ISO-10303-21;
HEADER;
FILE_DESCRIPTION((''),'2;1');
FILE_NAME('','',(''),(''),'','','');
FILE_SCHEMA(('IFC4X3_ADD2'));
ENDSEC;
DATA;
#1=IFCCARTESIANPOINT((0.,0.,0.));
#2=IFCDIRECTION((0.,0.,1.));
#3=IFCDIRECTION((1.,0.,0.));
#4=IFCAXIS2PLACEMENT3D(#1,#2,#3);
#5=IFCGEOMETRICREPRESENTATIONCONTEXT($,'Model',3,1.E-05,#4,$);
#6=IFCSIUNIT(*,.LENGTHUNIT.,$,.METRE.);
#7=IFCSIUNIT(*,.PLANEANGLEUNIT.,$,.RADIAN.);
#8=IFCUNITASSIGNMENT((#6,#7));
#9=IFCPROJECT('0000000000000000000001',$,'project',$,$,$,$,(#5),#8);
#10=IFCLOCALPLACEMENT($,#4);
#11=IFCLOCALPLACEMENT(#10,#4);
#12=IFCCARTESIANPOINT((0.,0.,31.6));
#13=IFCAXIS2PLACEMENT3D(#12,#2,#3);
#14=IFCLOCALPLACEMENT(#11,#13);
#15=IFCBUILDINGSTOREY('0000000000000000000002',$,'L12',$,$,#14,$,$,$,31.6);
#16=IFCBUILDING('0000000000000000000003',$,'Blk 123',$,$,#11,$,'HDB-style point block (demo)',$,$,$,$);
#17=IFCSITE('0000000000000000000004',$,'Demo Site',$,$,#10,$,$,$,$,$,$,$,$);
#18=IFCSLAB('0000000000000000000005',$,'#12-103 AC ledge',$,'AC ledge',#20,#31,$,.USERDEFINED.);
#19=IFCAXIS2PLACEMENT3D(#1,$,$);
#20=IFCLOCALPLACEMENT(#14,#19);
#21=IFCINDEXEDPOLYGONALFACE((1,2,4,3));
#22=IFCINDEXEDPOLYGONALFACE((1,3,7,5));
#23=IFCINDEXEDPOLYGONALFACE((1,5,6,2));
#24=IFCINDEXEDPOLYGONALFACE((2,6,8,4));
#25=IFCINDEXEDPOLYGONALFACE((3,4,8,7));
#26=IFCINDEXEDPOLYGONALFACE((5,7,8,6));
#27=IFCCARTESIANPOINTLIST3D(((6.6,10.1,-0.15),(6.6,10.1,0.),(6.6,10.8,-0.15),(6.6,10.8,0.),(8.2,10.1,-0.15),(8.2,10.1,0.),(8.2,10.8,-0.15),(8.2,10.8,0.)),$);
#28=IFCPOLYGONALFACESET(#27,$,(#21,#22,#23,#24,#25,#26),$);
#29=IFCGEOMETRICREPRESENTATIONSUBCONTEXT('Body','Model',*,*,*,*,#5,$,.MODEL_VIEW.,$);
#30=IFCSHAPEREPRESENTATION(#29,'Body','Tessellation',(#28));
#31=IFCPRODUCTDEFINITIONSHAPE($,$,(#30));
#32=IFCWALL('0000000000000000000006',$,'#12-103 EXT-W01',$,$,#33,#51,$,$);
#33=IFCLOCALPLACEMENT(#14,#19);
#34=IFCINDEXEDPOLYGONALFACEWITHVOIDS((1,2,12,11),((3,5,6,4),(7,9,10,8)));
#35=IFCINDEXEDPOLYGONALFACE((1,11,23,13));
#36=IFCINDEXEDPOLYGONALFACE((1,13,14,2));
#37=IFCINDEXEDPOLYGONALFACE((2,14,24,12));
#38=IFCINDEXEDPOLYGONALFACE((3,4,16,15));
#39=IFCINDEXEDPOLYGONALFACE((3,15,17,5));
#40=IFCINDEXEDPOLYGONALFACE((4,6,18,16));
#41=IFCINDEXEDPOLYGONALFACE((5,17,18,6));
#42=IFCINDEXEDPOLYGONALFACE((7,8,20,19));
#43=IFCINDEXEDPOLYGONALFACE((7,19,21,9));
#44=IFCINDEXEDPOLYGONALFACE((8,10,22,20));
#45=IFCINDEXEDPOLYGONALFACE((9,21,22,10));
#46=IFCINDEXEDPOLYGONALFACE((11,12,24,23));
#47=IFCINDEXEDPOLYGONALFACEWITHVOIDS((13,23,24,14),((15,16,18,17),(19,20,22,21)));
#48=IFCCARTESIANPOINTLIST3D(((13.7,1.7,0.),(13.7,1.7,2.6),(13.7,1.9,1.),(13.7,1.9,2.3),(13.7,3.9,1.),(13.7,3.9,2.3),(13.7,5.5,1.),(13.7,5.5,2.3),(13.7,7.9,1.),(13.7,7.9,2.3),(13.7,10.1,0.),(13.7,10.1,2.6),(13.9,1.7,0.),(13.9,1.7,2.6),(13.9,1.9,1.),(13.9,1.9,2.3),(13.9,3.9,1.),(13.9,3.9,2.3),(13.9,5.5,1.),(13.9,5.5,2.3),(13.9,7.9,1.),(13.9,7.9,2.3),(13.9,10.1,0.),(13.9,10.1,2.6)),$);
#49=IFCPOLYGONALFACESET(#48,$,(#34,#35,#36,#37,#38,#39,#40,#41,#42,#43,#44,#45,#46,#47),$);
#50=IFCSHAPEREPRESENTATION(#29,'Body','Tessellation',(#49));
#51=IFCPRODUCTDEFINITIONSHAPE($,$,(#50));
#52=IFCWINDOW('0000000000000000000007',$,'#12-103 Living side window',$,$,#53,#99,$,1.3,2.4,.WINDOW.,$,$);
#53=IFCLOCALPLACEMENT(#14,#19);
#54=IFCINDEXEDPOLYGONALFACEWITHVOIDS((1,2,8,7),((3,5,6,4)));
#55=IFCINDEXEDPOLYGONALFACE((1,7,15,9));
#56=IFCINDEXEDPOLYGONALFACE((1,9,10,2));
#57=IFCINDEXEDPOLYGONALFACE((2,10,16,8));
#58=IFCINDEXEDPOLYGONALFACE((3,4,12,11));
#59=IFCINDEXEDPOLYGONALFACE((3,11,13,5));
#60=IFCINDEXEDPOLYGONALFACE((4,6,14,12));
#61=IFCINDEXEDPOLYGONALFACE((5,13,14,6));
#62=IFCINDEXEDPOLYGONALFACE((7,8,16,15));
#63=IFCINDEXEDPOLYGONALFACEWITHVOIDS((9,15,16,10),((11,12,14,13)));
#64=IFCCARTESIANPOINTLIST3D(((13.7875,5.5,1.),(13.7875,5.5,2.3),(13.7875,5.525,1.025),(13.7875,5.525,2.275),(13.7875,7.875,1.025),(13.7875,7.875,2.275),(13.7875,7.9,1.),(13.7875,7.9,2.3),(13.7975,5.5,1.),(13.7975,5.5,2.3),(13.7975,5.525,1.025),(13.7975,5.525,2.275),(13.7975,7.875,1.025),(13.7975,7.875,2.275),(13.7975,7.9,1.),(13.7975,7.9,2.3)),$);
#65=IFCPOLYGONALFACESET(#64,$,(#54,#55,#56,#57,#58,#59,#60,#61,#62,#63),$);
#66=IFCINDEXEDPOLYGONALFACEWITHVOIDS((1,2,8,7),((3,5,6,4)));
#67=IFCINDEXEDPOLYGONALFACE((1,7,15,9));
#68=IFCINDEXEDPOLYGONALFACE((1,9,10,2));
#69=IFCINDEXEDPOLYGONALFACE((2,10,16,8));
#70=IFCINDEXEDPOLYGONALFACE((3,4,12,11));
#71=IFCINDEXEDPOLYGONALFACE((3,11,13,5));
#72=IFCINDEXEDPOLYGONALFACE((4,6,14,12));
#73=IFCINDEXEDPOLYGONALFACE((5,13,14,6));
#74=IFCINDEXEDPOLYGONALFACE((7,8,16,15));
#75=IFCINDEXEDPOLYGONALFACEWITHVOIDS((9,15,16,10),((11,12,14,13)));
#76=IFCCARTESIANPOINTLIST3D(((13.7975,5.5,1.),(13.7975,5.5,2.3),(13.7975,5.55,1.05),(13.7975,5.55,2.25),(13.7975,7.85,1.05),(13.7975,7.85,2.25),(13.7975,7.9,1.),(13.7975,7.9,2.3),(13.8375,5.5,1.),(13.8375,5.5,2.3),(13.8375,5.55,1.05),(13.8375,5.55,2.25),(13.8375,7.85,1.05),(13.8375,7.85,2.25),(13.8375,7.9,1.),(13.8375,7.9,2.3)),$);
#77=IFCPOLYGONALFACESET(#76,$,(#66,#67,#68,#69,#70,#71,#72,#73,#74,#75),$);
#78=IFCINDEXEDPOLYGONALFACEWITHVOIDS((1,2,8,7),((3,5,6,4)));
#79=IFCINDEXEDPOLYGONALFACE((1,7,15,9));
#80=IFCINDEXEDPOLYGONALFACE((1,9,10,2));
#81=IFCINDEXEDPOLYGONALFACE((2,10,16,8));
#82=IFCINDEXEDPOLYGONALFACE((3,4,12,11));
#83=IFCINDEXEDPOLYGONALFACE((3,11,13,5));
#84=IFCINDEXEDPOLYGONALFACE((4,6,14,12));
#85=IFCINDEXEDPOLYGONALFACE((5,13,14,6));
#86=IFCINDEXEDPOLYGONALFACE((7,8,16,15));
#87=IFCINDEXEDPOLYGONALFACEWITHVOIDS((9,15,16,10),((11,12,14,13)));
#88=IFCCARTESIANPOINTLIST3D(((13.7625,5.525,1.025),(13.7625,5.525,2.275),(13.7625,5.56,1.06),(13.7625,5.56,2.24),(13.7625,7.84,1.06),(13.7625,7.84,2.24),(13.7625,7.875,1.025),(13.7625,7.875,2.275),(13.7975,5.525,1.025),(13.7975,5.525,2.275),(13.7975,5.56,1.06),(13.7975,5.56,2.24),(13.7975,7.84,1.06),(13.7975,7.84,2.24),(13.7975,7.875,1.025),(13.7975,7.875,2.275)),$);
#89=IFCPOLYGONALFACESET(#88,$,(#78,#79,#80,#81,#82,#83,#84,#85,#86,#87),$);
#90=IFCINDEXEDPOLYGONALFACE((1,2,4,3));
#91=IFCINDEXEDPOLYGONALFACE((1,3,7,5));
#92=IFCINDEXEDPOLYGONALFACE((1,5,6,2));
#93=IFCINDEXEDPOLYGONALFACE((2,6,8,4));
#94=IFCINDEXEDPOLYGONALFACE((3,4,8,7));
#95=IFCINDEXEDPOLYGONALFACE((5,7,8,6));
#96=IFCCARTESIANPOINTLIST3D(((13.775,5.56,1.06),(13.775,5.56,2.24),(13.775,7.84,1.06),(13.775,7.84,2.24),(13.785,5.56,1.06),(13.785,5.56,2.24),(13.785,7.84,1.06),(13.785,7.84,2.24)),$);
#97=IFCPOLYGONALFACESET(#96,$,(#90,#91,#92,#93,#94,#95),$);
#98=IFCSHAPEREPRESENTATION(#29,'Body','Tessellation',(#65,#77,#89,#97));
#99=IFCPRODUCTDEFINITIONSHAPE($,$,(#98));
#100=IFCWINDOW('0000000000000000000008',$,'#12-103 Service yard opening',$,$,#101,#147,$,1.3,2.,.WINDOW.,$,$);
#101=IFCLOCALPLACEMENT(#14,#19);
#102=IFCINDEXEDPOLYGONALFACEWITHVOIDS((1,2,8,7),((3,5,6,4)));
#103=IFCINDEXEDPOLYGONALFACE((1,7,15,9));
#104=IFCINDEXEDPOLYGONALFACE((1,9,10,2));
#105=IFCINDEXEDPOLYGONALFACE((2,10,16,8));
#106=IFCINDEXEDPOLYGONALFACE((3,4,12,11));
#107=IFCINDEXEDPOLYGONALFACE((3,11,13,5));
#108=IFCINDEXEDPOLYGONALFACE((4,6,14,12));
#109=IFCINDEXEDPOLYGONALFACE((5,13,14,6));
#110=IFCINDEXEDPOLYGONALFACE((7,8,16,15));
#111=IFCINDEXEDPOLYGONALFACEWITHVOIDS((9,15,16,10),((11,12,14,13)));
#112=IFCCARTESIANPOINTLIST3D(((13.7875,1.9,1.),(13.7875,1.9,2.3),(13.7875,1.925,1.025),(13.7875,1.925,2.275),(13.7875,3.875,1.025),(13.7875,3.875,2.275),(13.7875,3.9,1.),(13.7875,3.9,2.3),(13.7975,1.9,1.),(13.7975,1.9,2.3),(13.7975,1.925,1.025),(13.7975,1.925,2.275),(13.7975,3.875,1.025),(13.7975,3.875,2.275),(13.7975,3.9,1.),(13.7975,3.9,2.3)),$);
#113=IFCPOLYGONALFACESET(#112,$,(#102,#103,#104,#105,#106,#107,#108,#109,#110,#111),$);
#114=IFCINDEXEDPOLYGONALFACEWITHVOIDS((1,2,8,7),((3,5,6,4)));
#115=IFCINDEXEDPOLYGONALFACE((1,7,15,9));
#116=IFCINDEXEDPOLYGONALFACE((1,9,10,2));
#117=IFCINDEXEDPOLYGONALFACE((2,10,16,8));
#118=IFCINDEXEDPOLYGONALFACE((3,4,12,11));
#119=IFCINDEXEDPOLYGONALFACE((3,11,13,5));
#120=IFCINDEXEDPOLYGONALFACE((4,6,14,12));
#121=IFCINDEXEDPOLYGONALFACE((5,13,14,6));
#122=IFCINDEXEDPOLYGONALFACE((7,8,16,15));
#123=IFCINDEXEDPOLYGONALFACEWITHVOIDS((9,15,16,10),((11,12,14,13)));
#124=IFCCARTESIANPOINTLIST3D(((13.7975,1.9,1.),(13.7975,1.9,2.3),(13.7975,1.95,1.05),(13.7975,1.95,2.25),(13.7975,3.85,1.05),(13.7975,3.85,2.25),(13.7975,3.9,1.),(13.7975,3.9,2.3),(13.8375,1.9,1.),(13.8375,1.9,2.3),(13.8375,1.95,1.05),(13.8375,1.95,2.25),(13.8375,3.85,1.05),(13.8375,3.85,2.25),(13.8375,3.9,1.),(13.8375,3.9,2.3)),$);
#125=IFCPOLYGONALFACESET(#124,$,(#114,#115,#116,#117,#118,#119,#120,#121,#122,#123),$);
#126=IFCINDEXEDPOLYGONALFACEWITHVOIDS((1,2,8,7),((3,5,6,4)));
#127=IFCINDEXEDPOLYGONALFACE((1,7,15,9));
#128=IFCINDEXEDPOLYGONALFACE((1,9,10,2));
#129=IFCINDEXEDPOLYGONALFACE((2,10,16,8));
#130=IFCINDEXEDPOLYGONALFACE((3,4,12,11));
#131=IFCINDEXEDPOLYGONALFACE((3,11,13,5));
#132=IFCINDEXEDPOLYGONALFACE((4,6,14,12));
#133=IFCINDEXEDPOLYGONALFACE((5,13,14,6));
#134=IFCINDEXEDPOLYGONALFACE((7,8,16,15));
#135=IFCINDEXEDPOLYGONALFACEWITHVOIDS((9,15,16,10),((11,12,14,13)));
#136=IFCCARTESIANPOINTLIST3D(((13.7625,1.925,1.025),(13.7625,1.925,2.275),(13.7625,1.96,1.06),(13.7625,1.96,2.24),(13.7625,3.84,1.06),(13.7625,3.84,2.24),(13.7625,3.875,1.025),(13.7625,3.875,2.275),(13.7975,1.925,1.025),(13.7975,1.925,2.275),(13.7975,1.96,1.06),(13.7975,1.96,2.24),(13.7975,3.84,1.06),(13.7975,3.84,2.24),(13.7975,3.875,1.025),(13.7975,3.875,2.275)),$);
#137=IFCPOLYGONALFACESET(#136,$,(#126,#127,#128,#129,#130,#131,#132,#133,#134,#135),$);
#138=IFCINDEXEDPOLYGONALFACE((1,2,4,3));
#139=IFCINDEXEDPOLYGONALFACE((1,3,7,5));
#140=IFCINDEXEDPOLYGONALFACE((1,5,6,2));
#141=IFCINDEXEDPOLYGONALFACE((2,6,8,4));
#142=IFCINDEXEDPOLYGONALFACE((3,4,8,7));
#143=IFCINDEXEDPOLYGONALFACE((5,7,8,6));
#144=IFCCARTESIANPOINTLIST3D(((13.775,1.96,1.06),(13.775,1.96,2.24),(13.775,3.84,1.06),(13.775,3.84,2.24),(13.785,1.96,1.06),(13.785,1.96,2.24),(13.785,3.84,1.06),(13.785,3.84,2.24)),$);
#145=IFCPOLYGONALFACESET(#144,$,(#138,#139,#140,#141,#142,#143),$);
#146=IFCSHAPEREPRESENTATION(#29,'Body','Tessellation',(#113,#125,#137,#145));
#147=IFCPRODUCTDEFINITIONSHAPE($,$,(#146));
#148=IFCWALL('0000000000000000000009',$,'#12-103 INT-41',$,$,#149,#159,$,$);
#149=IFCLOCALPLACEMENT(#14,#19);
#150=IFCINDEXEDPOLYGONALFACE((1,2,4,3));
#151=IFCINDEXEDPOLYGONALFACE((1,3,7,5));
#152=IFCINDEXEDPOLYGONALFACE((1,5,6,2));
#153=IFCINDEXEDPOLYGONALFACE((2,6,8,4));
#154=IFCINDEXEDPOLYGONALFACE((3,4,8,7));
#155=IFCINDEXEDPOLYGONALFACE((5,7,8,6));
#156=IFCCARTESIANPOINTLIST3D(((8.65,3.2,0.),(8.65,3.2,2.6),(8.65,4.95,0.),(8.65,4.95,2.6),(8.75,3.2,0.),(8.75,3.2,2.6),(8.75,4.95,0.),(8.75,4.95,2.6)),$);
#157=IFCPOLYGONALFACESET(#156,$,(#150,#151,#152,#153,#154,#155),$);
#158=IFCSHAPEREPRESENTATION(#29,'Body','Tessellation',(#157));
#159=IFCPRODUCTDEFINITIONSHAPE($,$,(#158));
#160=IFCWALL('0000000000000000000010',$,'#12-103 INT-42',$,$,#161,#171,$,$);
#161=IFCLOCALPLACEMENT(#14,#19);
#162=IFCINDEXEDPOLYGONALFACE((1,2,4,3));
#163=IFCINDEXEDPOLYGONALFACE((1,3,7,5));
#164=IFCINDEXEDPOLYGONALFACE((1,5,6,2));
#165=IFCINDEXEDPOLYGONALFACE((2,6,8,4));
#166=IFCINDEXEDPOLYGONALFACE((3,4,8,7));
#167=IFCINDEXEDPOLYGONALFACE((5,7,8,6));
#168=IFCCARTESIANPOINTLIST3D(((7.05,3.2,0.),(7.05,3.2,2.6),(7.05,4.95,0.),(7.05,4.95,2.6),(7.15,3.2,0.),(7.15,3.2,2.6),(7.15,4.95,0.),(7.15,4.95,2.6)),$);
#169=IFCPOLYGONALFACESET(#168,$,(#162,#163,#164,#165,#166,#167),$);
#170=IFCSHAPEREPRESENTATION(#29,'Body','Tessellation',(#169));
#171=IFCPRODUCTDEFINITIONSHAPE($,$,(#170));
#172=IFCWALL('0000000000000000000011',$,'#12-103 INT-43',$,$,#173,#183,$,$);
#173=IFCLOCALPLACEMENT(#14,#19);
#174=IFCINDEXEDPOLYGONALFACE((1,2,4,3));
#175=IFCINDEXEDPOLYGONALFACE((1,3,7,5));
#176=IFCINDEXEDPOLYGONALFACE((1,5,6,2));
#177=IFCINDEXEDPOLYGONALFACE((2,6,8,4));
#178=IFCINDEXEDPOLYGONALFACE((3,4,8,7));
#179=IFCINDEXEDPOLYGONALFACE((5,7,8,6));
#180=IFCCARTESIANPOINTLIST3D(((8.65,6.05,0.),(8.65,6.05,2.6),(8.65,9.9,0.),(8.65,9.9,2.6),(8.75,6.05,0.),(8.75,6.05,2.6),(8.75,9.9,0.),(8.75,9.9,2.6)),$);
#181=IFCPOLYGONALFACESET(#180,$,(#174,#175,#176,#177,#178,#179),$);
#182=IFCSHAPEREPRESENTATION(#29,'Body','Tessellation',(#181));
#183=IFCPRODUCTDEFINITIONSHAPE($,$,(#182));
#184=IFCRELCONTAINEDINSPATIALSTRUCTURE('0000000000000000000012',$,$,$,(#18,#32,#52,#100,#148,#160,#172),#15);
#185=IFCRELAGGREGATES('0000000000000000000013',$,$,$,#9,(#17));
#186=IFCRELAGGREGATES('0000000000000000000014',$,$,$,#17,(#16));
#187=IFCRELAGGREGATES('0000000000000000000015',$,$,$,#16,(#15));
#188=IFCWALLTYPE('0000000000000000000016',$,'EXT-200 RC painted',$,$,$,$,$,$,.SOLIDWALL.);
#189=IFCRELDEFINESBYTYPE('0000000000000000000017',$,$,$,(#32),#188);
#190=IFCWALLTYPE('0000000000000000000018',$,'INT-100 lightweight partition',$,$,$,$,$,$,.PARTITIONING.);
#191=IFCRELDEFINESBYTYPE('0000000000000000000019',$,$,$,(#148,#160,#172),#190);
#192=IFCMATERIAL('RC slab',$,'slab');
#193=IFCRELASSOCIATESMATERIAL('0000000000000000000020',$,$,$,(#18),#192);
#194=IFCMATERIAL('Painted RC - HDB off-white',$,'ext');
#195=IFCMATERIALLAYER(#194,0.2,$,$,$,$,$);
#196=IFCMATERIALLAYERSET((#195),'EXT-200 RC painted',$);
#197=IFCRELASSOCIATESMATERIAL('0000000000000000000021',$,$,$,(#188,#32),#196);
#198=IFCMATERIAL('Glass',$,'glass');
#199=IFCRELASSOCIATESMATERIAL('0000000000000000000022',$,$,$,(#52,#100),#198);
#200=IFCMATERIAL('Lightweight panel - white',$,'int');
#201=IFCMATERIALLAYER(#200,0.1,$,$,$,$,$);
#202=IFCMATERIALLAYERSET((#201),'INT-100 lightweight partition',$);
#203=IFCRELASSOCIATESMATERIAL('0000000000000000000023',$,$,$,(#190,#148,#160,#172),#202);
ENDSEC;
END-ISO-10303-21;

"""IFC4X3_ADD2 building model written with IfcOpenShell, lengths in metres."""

from ifc_helpers import new_model, si_unit, frame, origin, origin_with_axes, place, context, subcontext, project, spatial, polyline, line, indexed_curve, outline, extrude, material, layer, layer_set, layer_usage, type_object, element, fill, save


model = new_model("IFC4X3_ADD2")

# Units and contexts
model_context = context("Model", 3, precision=1e-05, world=origin_with_axes())
body_context = subcontext(model_context, "Body", "Model", "MODEL_VIEW")
ifc_project = project(units=[si_unit("LENGTHUNIT", "METRE"), si_unit("PLANEANGLEUNIT", "RADIAN")], contexts=[model_context])

# Site, building, storey
site_placement = place(None, origin_with_axes())
site = spatial("IfcSite", under=ifc_project, at=site_placement, Name="Demo Site")
building_placement = place(site_placement, origin_with_axes())
building = spatial("IfcBuilding", under=site, at=building_placement, Name="Blk 123", LongName="HDB-style point block (demo)")
storey_placement = place(building_placement, frame((0.0, 0.0, 31.6), z_axis=(0.0, 0.0, 1.0), x_axis=(1.0, 0.0, 0.0)))
storey = spatial("IfcBuildingStorey", under=building, at=storey_placement, Name="L12", Elevation=31.6)

# Slab
ifc_material_1 = material(Name="RC slab", Category="slab")
slab_placement = place(storey_placement, frame((7.4, 10.45, -0.15), z_axis=(0.0, 0.0, 1.0), x_axis=(1.0, 0.0, 0.0)))
element("IfcSlab", 1, at=slab_placement, inside=storey, material=ifc_material_1, Name="#12-103 AC ledge", ObjectType="AC ledge", PredefinedType="USERDEFINED", context=body_context, shape_type="SweptSolid", body=[
    extrude(outline(polyline([(0.8, -0.35), (0.8, 0.35), (-0.8, 0.35), (-0.8, -0.35), (0.8, -0.35)])), origin(), (0.0, 0.0, 1.0), 0.15),
])

# Wall, openings, windows
ifc_material_2 = material(Name="Painted RC - HDB off-white", Category="ext")
ifc_layer_1 = layer(ifc_material_2, 0.2)
ifc_layer_set_1 = layer_set([ifc_layer_1], Name="EXT-200 RC painted")
ifc_layer_usage_1 = layer_usage(ifc_layer_set_1, "AXIS2", "POSITIVE", 0.0)
wall_type_1 = type_object("IfcWallType", Name="EXT-200 RC painted", PredefinedType="SOLIDWALL", material=ifc_layer_set_1)
wall_1_placement = place(storey_placement, frame((13.9, 1.7, 0.0), z_axis=(0.0, 0.0, 1.0), x_axis=(0.0, 1.0, 0.0)))
wall_1 = element("IfcWall", 2, at=wall_1_placement, inside=storey, type_object=wall_type_1, material=ifc_layer_usage_1, Name="#12-103 EXT-W01", context=body_context, shape_type="SweptSolid", body=[
    extrude(outline(indexed_curve([(0.0, 0.0), (0.0, 0.2), (8.4, 0.2), (8.4, 0.0), (0.0, 0.0)], self_intersect=False)), origin_with_axes(), (0.0, 0.0, 1.0), 2.6),
])
opening_1_placement = place(wall_1_placement, frame((3.8, -0.1, 1.0), z_axis=(0.0, 0.0, 1.0), x_axis=(1.0, 0.0, 0.0)))
opening_1 = element("IfcOpeningElement", 3, at=opening_1_placement, cuts=wall_1, context=body_context, shape_type="SweptSolid", body=[
    extrude(outline(indexed_curve([(0.0, 0.0), (0.0, 0.4), (2.4, 0.4), (2.4, 0.0), (0.0, 0.0)], self_intersect=False)), origin_with_axes(), (0.0, 0.0, 1.0), 1.3),
])
opening_2_placement = place(wall_1_placement, frame((0.2, -0.1, 1.0), z_axis=(0.0, 0.0, 1.0), x_axis=(1.0, 0.0, 0.0)))
opening_2 = element("IfcOpeningElement", 4, at=opening_2_placement, cuts=wall_1, context=body_context, shape_type="SweptSolid", body=[
    extrude(outline(indexed_curve([(0.0, 0.0), (0.0, 0.4), (2.0, 0.4), (2.0, 0.0), (0.0, 0.0)], self_intersect=False)), origin_with_axes(), (0.0, 0.0, 1.0), 1.3),
])
ifc_material_3 = material(Name="Glass", Category="glass")
window_1_placement = place(opening_1_placement, frame((0.0, 0.1125, 0.0), z_axis=(0.0, 0.0, 1.0), x_axis=(1.0, 0.0, 0.0)))
window_1 = element("IfcWindow", 5, at=window_1_placement, inside=storey, material=ifc_material_3, Name="#12-103 Living side window", OverallHeight=1.3, OverallWidth=2.4, PredefinedType="WINDOW", context=body_context, shape_type="SweptSolid", body=[
    extrude(outline(indexed_curve([(0.0, 0.0), (2.4, 0.0), (2.4, 1.3), (0.0, 1.3)], segments=[line(1, 2, 3, 4, 1)]), holes=[indexed_curve([(0.025, 0.025), (2.375, 0.025), (2.375, 1.275), (0.025, 1.275)], segments=[line(1, 2, 3, 4, 1)])]), frame((0.0, 0.09, 0.0), z_axis=(0.0, -1.0, 0.0), x_axis=(1.0, 0.0, 0.0)), (0.0, 0.0, -1.0), 0.01),
    extrude(outline(indexed_curve([(0.0, 0.0), (2.4, 0.0), (2.4, 1.3), (0.0, 1.3)], segments=[line(1, 2, 3, 4, 1)]), holes=[indexed_curve([(0.05, 0.05), (2.35, 0.05), (2.35, 1.25), (0.05, 1.25)], segments=[line(1, 2, 3, 4, 1)])]), frame((0.0, 0.05, 0.0), z_axis=(0.0, -1.0, 0.0), x_axis=(1.0, 0.0, 0.0)), (0.0, 0.0, -1.0), 0.04),
    extrude(outline(indexed_curve([(0.0, 0.0), (2.35, 0.0), (2.35, 1.25), (0.0, 1.25)], segments=[line(1, 2, 3, 4, 1)]), holes=[indexed_curve([(0.035, 0.035), (2.315, 0.035), (2.315, 1.215), (0.035, 1.215)], segments=[line(1, 2, 3, 4, 1)])]), frame((0.025, 0.09, 0.025), z_axis=(0.0, -1.0, 0.0), x_axis=(1.0, 0.0, 0.0)), (0.0, 0.0, -1.0), 0.035),
    extrude(outline(indexed_curve([(0.035, 0.035), (2.315, 0.035), (2.315, 1.215), (0.035, 1.215)], segments=[line(1, 2, 3, 4, 1)])), frame((0.025, 0.1025, 0.025), z_axis=(0.0, -1.0, 0.0), x_axis=(1.0, 0.0, 0.0)), (0.0, 0.0, -1.0), 0.01),
])
fill(opening_1, window_1)
window_2_placement = place(opening_2_placement, frame((0.0, 0.1125, 0.0), z_axis=(0.0, 0.0, 1.0), x_axis=(1.0, 0.0, 0.0)))
window_2 = element("IfcWindow", 6, at=window_2_placement, inside=storey, material=ifc_material_3, Name="#12-103 Service yard opening", OverallHeight=1.3, OverallWidth=2.0, PredefinedType="WINDOW", context=body_context, shape_type="SweptSolid", body=[
    extrude(outline(indexed_curve([(0.0, 0.0), (2.0, 0.0), (2.0, 1.3), (0.0, 1.3)], segments=[line(1, 2, 3, 4, 1)]), holes=[indexed_curve([(0.025, 0.025), (1.975, 0.025), (1.975, 1.275), (0.025, 1.275)], segments=[line(1, 2, 3, 4, 1)])]), frame((0.0, 0.09, 0.0), z_axis=(0.0, -1.0, 0.0), x_axis=(1.0, 0.0, 0.0)), (0.0, 0.0, -1.0), 0.01),
    extrude(outline(indexed_curve([(0.0, 0.0), (2.0, 0.0), (2.0, 1.3), (0.0, 1.3)], segments=[line(1, 2, 3, 4, 1)]), holes=[indexed_curve([(0.05, 0.05), (1.95, 0.05), (1.95, 1.25), (0.05, 1.25)], segments=[line(1, 2, 3, 4, 1)])]), frame((0.0, 0.05, 0.0), z_axis=(0.0, -1.0, 0.0), x_axis=(1.0, 0.0, 0.0)), (0.0, 0.0, -1.0), 0.04),
    extrude(outline(indexed_curve([(0.0, 0.0), (1.95, 0.0), (1.95, 1.25), (0.0, 1.25)], segments=[line(1, 2, 3, 4, 1)]), holes=[indexed_curve([(0.035, 0.035), (1.915, 0.035), (1.915, 1.215), (0.035, 1.215)], segments=[line(1, 2, 3, 4, 1)])]), frame((0.025, 0.09, 0.025), z_axis=(0.0, -1.0, 0.0), x_axis=(1.0, 0.0, 0.0)), (0.0, 0.0, -1.0), 0.035),
    extrude(outline(indexed_curve([(0.035, 0.035), (1.915, 0.035), (1.915, 1.215), (0.035, 1.215)], segments=[line(1, 2, 3, 4, 1)])), frame((0.025, 0.1025, 0.025), z_axis=(0.0, -1.0, 0.0), x_axis=(1.0, 0.0, 0.0)), (0.0, 0.0, -1.0), 0.01),
])
fill(opening_2, window_2)

# Walls
ifc_material_4 = material(Name="Lightweight panel - white", Category="int")
ifc_layer_2 = layer(ifc_material_4, 0.1)
ifc_layer_set_2 = layer_set([ifc_layer_2], Name="INT-100 lightweight partition")
ifc_layer_usage_2 = layer_usage(ifc_layer_set_2, "AXIS2", "POSITIVE", -0.05)
wall_type_2 = type_object("IfcWallType", Name="INT-100 lightweight partition", PredefinedType="PARTITIONING", material=ifc_layer_set_2)
for number, where, z_axis, x_axis, name in (
    (7, (8.7, 3.2, 0.0), (0.0, 0.0, 1.0), (0.0, 1.0, 0.0), "#12-103 INT-41"),
    (8, (7.1, 3.2, 0.0), (0.0, 0.0, 1.0), (0.0, 1.0, 0.0), "#12-103 INT-42"),
):
    element("IfcWall", number, at=place(storey_placement, frame(where, z_axis=z_axis, x_axis=x_axis)), inside=storey, type_object=wall_type_2, material=ifc_layer_usage_2, Name=name, context=body_context, shape_type="SweptSolid", body=[
        extrude(outline(indexed_curve([(0.0, 0.0), (0.0, 0.1), (1.75, 0.1), (1.75, 0.0), (0.0, 0.0)], self_intersect=False)), frame((0.0, -0.05, 0.0), z_axis=(0.0, 0.0, 1.0), x_axis=(1.0, 0.0, 0.0)), (0.0, 0.0, 1.0), 2.6),
    ])
wall_2_placement = place(storey_placement, frame((8.7, 6.05, 0.0), z_axis=(0.0, 0.0, 1.0), x_axis=(0.0, 1.0, 0.0)))
element("IfcWall", 9, at=wall_2_placement, inside=storey, type_object=wall_type_2, material=ifc_layer_usage_2, Name="#12-103 INT-43", context=body_context, shape_type="SweptSolid", body=[
    extrude(outline(indexed_curve([(0.0, 0.0), (0.0, 0.1), (3.85, 0.1), (3.85, 0.0), (0.0, 0.0)], self_intersect=False)), frame((0.0, -0.05, 0.0), z_axis=(0.0, 0.0, 1.0), x_axis=(1.0, 0.0, 0.0)), (0.0, 0.0, 1.0), 2.6),
])

save(model, "model.ifc")
